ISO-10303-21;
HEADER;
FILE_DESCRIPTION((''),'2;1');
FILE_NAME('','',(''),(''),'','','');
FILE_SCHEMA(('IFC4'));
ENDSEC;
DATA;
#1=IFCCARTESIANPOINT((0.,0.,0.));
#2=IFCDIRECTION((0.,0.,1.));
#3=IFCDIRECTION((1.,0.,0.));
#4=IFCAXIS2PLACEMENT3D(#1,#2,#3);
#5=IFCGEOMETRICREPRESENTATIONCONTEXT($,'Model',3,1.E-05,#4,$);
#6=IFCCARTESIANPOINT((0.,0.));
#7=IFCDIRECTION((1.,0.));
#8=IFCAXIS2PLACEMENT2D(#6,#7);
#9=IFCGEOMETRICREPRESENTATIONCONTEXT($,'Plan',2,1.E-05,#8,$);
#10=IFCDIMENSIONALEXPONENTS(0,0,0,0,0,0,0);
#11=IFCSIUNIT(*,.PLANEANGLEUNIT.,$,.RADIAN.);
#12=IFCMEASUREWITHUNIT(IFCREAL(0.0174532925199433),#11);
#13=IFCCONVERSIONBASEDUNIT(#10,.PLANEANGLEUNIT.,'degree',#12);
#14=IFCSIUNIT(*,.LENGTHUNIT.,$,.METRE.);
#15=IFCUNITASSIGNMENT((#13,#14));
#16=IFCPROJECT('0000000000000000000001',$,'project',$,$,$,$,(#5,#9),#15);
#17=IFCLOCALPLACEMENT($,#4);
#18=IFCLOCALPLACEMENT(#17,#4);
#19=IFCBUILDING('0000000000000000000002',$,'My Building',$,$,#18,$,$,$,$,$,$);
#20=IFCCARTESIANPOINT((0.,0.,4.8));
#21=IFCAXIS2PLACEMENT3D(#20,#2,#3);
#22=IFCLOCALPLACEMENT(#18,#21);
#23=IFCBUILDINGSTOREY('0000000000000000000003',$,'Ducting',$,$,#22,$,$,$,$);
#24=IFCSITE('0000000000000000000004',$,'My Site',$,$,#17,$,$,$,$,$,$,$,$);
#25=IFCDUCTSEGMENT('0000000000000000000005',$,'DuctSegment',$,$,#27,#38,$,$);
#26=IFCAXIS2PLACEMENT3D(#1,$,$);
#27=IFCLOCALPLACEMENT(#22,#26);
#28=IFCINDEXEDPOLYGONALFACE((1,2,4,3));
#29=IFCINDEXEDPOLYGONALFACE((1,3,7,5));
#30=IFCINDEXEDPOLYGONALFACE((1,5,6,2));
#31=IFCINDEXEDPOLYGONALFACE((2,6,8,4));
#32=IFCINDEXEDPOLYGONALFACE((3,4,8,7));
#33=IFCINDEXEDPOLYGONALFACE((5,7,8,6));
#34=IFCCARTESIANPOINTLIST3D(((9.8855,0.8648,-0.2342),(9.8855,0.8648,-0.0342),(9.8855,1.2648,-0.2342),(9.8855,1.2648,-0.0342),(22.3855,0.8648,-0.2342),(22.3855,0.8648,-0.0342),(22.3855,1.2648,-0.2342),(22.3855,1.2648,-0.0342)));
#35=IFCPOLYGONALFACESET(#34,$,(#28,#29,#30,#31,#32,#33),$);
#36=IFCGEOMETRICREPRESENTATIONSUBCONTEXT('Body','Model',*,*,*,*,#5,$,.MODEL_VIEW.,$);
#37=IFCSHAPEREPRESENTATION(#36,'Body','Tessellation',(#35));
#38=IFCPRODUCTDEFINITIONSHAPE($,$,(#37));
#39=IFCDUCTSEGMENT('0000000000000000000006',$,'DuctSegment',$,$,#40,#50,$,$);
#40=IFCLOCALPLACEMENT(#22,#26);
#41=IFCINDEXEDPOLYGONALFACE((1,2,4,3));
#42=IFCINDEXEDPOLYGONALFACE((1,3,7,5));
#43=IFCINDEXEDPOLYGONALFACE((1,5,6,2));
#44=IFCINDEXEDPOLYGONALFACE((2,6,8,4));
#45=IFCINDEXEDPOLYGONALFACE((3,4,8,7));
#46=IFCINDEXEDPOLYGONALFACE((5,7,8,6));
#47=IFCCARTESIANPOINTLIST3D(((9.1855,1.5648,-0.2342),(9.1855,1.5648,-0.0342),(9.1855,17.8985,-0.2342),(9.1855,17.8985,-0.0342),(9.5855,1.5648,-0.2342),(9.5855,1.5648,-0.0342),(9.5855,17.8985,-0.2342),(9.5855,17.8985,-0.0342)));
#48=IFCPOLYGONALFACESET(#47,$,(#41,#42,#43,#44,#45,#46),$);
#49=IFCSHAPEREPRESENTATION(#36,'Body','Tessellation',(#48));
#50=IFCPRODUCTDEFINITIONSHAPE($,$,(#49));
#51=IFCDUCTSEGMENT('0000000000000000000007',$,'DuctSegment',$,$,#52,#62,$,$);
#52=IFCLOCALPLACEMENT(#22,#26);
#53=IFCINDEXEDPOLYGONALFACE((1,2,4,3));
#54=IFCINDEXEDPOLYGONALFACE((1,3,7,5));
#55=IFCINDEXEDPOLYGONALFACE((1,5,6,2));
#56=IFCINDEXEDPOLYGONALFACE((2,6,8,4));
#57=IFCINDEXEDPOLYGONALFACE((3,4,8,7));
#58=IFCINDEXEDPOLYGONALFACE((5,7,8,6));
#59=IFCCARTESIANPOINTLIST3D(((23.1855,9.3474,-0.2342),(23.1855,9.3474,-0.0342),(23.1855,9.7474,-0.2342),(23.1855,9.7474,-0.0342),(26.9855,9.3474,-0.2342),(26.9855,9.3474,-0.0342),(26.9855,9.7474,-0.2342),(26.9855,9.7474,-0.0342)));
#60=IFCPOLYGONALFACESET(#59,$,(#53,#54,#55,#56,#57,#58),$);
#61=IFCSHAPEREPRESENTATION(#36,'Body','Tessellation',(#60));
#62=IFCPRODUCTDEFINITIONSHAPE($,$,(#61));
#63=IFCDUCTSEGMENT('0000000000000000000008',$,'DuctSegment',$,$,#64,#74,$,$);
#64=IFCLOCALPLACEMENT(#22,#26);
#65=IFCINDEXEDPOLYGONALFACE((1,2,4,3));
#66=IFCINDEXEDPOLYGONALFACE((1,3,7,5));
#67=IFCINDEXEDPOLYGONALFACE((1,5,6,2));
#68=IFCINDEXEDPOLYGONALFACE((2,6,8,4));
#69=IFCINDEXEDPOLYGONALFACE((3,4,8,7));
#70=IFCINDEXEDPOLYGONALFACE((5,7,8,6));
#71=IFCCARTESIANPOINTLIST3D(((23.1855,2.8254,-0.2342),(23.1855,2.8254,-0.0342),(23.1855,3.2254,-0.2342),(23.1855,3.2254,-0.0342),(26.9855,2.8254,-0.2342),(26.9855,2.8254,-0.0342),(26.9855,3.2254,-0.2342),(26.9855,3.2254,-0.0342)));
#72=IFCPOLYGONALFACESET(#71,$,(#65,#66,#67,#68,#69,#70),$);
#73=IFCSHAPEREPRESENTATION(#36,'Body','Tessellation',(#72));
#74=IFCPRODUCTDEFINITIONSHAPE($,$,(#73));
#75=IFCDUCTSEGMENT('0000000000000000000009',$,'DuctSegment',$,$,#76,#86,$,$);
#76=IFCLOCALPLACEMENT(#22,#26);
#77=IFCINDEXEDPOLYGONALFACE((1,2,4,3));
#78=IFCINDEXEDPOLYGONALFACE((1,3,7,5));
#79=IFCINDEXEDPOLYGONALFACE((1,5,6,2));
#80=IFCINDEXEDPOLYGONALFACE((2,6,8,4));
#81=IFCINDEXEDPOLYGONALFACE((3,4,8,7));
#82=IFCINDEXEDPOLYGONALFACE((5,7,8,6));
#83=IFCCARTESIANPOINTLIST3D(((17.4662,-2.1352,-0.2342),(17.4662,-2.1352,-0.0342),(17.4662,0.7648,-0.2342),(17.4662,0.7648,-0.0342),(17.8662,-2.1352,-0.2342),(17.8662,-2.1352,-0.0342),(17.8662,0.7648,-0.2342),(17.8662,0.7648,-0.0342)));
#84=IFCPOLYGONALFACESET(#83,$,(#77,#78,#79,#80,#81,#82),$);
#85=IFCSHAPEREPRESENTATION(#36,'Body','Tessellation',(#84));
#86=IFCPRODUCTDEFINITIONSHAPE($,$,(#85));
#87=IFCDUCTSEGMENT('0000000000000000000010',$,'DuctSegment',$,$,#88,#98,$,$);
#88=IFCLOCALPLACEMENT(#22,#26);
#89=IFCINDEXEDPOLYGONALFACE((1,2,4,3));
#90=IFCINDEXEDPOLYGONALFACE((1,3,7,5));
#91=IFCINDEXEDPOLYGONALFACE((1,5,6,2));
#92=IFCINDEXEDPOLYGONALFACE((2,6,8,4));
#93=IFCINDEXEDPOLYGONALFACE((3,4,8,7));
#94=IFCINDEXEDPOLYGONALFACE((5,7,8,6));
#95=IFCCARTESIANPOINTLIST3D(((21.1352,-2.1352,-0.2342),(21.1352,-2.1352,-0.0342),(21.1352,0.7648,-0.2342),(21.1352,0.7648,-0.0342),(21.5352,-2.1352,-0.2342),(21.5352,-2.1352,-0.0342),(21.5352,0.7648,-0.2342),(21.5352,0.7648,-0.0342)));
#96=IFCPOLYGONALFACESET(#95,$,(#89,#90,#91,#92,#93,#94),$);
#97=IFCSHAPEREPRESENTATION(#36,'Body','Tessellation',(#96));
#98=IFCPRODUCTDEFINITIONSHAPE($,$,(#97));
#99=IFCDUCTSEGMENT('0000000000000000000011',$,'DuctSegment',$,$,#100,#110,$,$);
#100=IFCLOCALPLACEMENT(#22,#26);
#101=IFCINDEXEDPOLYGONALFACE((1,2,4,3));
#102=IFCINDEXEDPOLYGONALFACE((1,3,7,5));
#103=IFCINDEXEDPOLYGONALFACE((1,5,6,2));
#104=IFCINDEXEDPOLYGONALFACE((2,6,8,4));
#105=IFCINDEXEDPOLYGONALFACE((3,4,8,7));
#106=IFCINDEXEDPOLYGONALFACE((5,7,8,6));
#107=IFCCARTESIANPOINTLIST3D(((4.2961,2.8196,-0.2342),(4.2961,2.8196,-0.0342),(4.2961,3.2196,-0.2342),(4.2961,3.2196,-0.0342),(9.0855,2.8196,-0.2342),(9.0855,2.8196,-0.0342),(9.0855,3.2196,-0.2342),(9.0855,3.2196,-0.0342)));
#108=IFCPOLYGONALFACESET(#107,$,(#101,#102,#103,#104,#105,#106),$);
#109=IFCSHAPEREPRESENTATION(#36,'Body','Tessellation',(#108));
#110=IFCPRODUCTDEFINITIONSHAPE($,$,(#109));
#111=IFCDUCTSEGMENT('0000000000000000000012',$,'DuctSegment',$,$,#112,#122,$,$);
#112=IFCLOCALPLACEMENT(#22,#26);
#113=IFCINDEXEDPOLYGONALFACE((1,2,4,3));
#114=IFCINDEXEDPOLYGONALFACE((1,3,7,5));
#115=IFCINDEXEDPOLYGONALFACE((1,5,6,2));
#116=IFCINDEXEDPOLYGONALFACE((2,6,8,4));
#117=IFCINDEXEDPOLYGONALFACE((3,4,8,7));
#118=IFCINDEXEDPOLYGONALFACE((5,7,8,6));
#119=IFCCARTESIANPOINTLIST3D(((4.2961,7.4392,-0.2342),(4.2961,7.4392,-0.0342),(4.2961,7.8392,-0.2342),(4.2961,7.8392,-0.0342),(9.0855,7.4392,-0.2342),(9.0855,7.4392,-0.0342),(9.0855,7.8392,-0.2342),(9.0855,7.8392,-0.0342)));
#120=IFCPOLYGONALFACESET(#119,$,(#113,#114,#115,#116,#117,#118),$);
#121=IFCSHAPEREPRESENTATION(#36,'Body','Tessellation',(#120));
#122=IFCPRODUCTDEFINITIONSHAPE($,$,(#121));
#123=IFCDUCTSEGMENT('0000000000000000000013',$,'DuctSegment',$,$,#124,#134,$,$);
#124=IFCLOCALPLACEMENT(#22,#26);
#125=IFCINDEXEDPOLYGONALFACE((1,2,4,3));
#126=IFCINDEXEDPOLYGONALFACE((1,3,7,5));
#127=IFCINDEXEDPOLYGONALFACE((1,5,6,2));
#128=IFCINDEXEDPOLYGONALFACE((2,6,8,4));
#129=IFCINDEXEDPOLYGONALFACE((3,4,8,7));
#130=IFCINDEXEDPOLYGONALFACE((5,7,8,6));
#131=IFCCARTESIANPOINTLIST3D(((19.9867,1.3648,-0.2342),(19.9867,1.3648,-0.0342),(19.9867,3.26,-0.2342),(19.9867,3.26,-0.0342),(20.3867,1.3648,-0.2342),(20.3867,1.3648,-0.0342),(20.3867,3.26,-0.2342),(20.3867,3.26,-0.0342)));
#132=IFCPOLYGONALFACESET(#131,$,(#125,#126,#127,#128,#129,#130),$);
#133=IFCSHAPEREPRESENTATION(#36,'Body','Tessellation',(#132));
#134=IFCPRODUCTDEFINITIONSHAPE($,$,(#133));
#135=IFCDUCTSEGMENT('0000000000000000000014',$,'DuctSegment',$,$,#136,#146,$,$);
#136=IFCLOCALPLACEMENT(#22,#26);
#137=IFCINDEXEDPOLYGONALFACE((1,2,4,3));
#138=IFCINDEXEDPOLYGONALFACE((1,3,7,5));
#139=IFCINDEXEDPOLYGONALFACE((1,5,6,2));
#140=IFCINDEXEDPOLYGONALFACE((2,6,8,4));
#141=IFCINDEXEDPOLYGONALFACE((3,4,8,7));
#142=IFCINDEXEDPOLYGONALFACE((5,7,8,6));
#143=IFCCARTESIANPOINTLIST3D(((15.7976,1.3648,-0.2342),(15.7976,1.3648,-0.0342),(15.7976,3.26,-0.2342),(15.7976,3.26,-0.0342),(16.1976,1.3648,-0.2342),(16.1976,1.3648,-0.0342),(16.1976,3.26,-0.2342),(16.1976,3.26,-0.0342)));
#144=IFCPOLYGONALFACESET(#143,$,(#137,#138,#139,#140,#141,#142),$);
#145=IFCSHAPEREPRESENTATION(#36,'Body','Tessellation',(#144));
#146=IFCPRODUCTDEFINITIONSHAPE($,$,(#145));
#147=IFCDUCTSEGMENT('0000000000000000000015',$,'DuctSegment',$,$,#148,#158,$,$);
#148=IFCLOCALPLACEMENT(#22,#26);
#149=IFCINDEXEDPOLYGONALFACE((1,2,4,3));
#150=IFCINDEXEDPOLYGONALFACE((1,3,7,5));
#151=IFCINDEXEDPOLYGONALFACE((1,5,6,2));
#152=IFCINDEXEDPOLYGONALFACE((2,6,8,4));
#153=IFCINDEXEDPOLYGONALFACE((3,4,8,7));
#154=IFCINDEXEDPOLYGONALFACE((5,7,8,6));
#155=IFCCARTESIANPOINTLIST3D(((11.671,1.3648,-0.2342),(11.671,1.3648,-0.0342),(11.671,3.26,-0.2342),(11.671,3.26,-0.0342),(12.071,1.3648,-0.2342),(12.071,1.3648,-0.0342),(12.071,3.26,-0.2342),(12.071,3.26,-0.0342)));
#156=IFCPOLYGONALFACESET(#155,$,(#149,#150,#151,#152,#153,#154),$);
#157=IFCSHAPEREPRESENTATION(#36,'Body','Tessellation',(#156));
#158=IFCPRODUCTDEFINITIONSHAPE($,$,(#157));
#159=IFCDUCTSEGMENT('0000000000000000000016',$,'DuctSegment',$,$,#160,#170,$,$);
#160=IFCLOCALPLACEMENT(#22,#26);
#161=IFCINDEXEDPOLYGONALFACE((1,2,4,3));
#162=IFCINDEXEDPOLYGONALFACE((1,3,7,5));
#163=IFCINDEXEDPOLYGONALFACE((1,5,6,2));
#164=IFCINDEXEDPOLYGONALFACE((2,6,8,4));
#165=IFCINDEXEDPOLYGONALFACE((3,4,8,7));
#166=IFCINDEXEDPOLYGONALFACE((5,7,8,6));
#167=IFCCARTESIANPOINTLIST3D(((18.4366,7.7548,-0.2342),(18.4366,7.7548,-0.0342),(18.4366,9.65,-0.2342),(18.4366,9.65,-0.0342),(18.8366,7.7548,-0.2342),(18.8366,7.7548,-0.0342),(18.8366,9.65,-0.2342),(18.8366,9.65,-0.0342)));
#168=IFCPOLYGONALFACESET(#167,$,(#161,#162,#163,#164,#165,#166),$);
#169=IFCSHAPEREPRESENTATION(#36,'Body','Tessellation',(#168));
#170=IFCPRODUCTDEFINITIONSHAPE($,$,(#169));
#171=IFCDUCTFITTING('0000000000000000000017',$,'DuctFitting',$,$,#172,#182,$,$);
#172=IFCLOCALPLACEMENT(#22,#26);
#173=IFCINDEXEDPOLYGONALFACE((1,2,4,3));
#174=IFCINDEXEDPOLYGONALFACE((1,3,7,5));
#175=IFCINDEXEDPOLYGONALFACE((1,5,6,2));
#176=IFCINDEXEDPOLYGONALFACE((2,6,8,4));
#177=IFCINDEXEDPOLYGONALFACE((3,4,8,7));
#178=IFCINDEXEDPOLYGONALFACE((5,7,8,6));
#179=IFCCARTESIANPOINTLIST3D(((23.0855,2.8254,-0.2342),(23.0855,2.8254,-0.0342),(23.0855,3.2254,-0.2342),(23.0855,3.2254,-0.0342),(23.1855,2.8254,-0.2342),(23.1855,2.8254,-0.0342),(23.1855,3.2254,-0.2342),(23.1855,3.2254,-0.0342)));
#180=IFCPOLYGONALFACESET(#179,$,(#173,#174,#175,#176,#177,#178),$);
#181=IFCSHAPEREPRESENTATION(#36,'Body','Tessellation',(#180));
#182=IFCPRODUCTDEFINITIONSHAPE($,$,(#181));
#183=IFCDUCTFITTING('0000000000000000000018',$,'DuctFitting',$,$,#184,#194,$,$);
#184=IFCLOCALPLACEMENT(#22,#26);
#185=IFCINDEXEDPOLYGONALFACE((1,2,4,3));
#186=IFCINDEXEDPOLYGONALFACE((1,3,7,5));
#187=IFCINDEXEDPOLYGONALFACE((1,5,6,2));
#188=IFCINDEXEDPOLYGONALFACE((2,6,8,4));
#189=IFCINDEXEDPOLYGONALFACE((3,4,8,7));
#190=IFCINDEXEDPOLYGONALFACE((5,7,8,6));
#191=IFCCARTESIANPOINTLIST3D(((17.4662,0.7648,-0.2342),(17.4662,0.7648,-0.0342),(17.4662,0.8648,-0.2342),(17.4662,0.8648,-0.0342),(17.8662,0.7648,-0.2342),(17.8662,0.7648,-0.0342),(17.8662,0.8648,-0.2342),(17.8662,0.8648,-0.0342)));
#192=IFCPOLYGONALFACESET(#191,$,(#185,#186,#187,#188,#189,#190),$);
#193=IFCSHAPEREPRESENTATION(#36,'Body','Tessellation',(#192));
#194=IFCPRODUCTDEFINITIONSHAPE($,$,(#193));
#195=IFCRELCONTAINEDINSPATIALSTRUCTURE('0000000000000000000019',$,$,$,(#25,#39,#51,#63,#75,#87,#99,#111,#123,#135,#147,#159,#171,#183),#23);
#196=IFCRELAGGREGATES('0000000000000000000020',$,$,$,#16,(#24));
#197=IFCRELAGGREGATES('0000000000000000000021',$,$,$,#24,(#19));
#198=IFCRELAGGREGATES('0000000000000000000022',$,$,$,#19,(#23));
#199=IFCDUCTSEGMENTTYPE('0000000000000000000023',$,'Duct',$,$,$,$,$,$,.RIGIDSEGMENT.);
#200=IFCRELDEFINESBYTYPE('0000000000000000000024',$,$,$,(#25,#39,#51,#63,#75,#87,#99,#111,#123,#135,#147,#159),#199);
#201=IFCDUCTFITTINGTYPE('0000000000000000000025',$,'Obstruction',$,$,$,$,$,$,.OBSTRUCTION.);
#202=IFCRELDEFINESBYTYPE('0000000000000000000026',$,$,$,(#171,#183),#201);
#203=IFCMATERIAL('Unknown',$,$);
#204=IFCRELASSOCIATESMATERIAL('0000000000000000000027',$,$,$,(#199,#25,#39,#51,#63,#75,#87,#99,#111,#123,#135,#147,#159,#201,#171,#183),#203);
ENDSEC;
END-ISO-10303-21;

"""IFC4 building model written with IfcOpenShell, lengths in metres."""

from ifc_helpers import new_model, entity, si_unit, converted_unit, frame, origin_with_axes, origin_2d_with_axis, place, context, subcontext, project, spatial, rectangle, extrude, material, material_profile, profile_set, profile_usage, type_object, element, save


model = new_model("IFC4")

# Units and contexts
model_context = context("Model", 3, precision=1e-05, world=origin_with_axes())
plan_context = context("Plan", 2, precision=1e-05, world=origin_2d_with_axis())
body_context = subcontext(model_context, "Body", "Model", "MODEL_VIEW")
ifc_project = project(units=[converted_unit("PLANEANGLEUNIT", "degree", entity("IfcReal", 0.0174532925199433), si_unit("PLANEANGLEUNIT", "RADIAN"), dimensions=[0, 0, 0, 0, 0, 0, 0]), si_unit("LENGTHUNIT", "METRE")], contexts=[model_context, plan_context])

# Site, building, storey
site_placement = place(None, origin_with_axes())
site = spatial("IfcSite", under=ifc_project, at=site_placement, Name="My Site")
building_placement = place(site_placement, origin_with_axes())
building = spatial("IfcBuilding", under=site, at=building_placement, Name="My Building")
storey_placement = place(building_placement, frame((0.0, 0.0, 4.8), z_axis=(0.0, 0.0, 1.0), x_axis=(1.0, 0.0, 0.0)))
storey = spatial("IfcBuildingStorey", under=building, at=storey_placement, Name="Ducting")

# Duct segments
ifc_material = material(Name="Unknown")
ifc_material_profile_1 = material_profile(ifc_material, rectangle(XDim=0.4, YDim=0.2))
ifc_profile_set_1 = profile_set([ifc_material_profile_1])
ifc_profile_usage_1 = profile_usage(ifc_profile_set_1, cardinal=5)
duct_segment_type = type_object("IfcDuctSegmentType", Name="Duct", PredefinedType="RIGIDSEGMENT", material=ifc_profile_set_1)
duct_segment_1_placement = place(storey_placement, frame((22.3855, 1.0648, -0.1342), z_axis=(-1.0, 0.0, 0.0), x_axis=(0.0, -1.0, 0.0)))
element("IfcDuctSegment", 1, at=duct_segment_1_placement, inside=storey, type_object=duct_segment_type, material=ifc_profile_usage_1, Name="DuctSegment", context=body_context, shape_type="SweptSolid", body=[
    extrude(rectangle(XDim=0.4, YDim=0.2), origin_with_axes(), (0.0, 0.0, 1.0), 12.5),
])
ifc_profile_usage_2 = profile_usage(ifc_profile_set_1, cardinal=5)
duct_segment_2_placement = place(storey_placement, frame((9.3855, 1.5648, -0.1342), z_axis=(0.0, 1.0, 0.0), x_axis=(-1.0, 0.0, 0.0)))
element("IfcDuctSegment", 2, at=duct_segment_2_placement, inside=storey, type_object=duct_segment_type, material=ifc_profile_usage_2, Name="DuctSegment", context=body_context, shape_type="SweptSolid", body=[
    extrude(rectangle(XDim=0.4, YDim=0.2), origin_with_axes(), (0.0, 0.0, 1.0), 16.3337),
])
ifc_profile_usage_3 = profile_usage(ifc_profile_set_1, cardinal=5)
duct_segment_3_placement = place(storey_placement, frame((23.1855, 9.5474, -0.1342), z_axis=(1.0, -0.000001, 0.000001), x_axis=(0.000001, 1.0, 0.0)))
element("IfcDuctSegment", 3, at=duct_segment_3_placement, inside=storey, type_object=duct_segment_type, material=ifc_profile_usage_3, Name="DuctSegment", context=body_context, shape_type="SweptSolid", body=[
    extrude(rectangle(XDim=0.4, YDim=0.2), origin_with_axes(), (0.0, 0.0, 1.0), 3.8),
])
ifc_profile_usage_4 = profile_usage(ifc_profile_set_1, cardinal=5)
duct_segment_4_placement = place(storey_placement, frame((23.1855, 3.0254, -0.1342), z_axis=(1.0, -0.000001, 0.000001), x_axis=(0.000001, 1.0, 0.0)))
element("IfcDuctSegment", 4, at=duct_segment_4_placement, inside=storey, type_object=duct_segment_type, material=ifc_profile_usage_4, Name="DuctSegment", context=body_context, shape_type="SweptSolid", body=[
    extrude(rectangle(XDim=0.4, YDim=0.2), origin_with_axes(), (0.0, 0.0, 1.0), 3.8),
])
ifc_profile_usage_5 = profile_usage(ifc_profile_set_1, cardinal=5)
duct_segment_5_placement = place(storey_placement, frame((17.6662, 0.7648, -0.1342), z_axis=(0.0, -1.0, -0.000001), x_axis=(1.0, 0.0, 0.0)))
element("IfcDuctSegment", 5, at=duct_segment_5_placement, inside=storey, type_object=duct_segment_type, material=ifc_profile_usage_5, Name="DuctSegment", context=body_context, shape_type="SweptSolid", body=[
    extrude(rectangle(XDim=0.4, YDim=0.2), origin_with_axes(), (0.0, 0.0, 1.0), 2.9),
])
ifc_profile_usage_6 = profile_usage(ifc_profile_set_1, cardinal=5)
duct_segment_6_placement = place(storey_placement, frame((21.3352, 0.7648, -0.1342), z_axis=(0.0, -1.0, -0.000001), x_axis=(1.0, 0.0, 0.0)))
element("IfcDuctSegment", 6, at=duct_segment_6_placement, inside=storey, type_object=duct_segment_type, material=ifc_profile_usage_6, Name="DuctSegment", context=body_context, shape_type="SweptSolid", body=[
    extrude(rectangle(XDim=0.4, YDim=0.2), origin_with_axes(), (0.0, 0.0, 1.0), 2.9),
])
ifc_profile_usage_7 = profile_usage(ifc_profile_set_1, cardinal=5)
duct_segment_7_placement = place(storey_placement, frame((9.0855, 3.0196, -0.1342), z_axis=(-1.0, 0.0, 0.0), x_axis=(0.0, -1.0, 0.0)))
element("IfcDuctSegment", 7, at=duct_segment_7_placement, inside=storey, type_object=duct_segment_type, material=ifc_profile_usage_7, Name="DuctSegment", context=body_context, shape_type="SweptSolid", body=[
    extrude(rectangle(XDim=0.4, YDim=0.2), origin_with_axes(), (0.0, 0.0, 1.0), 4.7893),
])
ifc_profile_usage_8 = profile_usage(ifc_profile_set_1, cardinal=5)
duct_segment_8_placement = place(storey_placement, frame((9.0855, 7.6392, -0.1342), z_axis=(-1.0, 0.0, 0.0), x_axis=(0.0, -1.0, 0.0)))
element("IfcDuctSegment", 8, at=duct_segment_8_placement, inside=storey, type_object=duct_segment_type, material=ifc_profile_usage_8, Name="DuctSegment", context=body_context, shape_type="SweptSolid", body=[
    extrude(rectangle(XDim=0.4, YDim=0.2), origin_with_axes(), (0.0, 0.0, 1.0), 4.7893),
])
ifc_profile_usage_9 = profile_usage(ifc_profile_set_1, cardinal=5)
duct_segment_9_placement = place(storey_placement, frame((20.1867, 3.26, -0.1342), z_axis=(0.000001, -1.0, 0.0), x_axis=(1.0, 0.000001, 0.0)))
element("IfcDuctSegment", 9, at=duct_segment_9_placement, inside=storey, type_object=duct_segment_type, material=ifc_profile_usage_9, Name="DuctSegment", context=body_context, shape_type="SweptSolid", body=[
    extrude(rectangle(XDim=0.4, YDim=0.2), origin_with_axes(), (0.0, 0.0, 1.0), 1.8952),
])
ifc_profile_usage_10 = profile_usage(ifc_profile_set_1, cardinal=5)
duct_segment_10_placement = place(storey_placement, frame((15.9976, 3.26, -0.1342), z_axis=(0.000001, -1.0, 0.0), x_axis=(1.0, 0.000001, 0.0)))
element("IfcDuctSegment", 10, at=duct_segment_10_placement, inside=storey, type_object=duct_segment_type, material=ifc_profile_usage_10, Name="DuctSegment", context=body_context, shape_type="SweptSolid", body=[
    extrude(rectangle(XDim=0.4, YDim=0.2), origin_with_axes(), (0.0, 0.0, 1.0), 1.8952),
])
ifc_profile_usage_11 = profile_usage(ifc_profile_set_1, cardinal=5)
duct_segment_11_placement = place(storey_placement, frame((11.871, 3.26, -0.1342), z_axis=(0.000001, -1.0, 0.0), x_axis=(1.0, 0.000001, 0.0)))
element("IfcDuctSegment", 11, at=duct_segment_11_placement, inside=storey, type_object=duct_segment_type, material=ifc_profile_usage_11, Name="DuctSegment", context=body_context, shape_type="SweptSolid", body=[
    extrude(rectangle(XDim=0.4, YDim=0.2), origin_with_axes(), (0.0, 0.0, 1.0), 1.8952),
])
ifc_profile_usage_12 = profile_usage(ifc_profile_set_1, cardinal=5)
duct_segment_12_placement = place(storey_placement, frame((18.6366, 7.7548, -0.1342), z_axis=(0.0, 1.0, 0.0), x_axis=(-1.0, 0.0, 0.0)))
element("IfcDuctSegment", 12, at=duct_segment_12_placement, inside=storey, type_object=duct_segment_type, material=ifc_profile_usage_12, Name="DuctSegment", context=body_context, shape_type="SweptSolid", body=[
    extrude(rectangle(XDim=0.4, YDim=0.2), origin_with_axes(), (0.0, 0.0, 1.0), 1.8952),
])

# Duct fittings
ifc_material_profile_2 = material_profile(ifc_material, rectangle(XDim=0.4, YDim=0.2))
ifc_profile_set_2 = profile_set([ifc_material_profile_2])
ifc_profile_usage_13 = profile_usage(ifc_profile_set_2, cardinal=5)
duct_fitting_type_1 = type_object("IfcDuctFittingType", Name="Obstruction", PredefinedType="OBSTRUCTION", material=ifc_profile_set_2)
duct_fitting_1_placement = place(storey_placement, frame((23.0855, 3.0254, -0.1342), z_axis=(1.0, -0.000001, 0.000001), x_axis=(0.000001, 1.0, 0.0)))
element("IfcDuctFitting", 13, at=duct_fitting_1_placement, inside=storey, type_object=duct_fitting_type_1, material=ifc_profile_usage_13, Name="DuctFitting", context=body_context, shape_type="SweptSolid", body=[
    extrude(rectangle(XDim=0.4, YDim=0.2), origin_with_axes(), (0.0, 0.0, 1.0), 0.1),
])
ifc_profile_usage_14 = profile_usage(ifc_profile_set_2, cardinal=5)
duct_fitting_2_placement = place(storey_placement, frame((17.6662, 0.8648, -0.1342), z_axis=(0.0, -1.0, -0.000001), x_axis=(1.0, 0.0, 0.0)))
element("IfcDuctFitting", 14, at=duct_fitting_2_placement, inside=storey, type_object=duct_fitting_type_1, material=ifc_profile_usage_14, Name="DuctFitting", context=body_context, shape_type="SweptSolid", body=[
    extrude(rectangle(XDim=0.4, YDim=0.2), origin_with_axes(), (0.0, 0.0, 1.0), 0.1),
])

save(model, "model.ifc")
